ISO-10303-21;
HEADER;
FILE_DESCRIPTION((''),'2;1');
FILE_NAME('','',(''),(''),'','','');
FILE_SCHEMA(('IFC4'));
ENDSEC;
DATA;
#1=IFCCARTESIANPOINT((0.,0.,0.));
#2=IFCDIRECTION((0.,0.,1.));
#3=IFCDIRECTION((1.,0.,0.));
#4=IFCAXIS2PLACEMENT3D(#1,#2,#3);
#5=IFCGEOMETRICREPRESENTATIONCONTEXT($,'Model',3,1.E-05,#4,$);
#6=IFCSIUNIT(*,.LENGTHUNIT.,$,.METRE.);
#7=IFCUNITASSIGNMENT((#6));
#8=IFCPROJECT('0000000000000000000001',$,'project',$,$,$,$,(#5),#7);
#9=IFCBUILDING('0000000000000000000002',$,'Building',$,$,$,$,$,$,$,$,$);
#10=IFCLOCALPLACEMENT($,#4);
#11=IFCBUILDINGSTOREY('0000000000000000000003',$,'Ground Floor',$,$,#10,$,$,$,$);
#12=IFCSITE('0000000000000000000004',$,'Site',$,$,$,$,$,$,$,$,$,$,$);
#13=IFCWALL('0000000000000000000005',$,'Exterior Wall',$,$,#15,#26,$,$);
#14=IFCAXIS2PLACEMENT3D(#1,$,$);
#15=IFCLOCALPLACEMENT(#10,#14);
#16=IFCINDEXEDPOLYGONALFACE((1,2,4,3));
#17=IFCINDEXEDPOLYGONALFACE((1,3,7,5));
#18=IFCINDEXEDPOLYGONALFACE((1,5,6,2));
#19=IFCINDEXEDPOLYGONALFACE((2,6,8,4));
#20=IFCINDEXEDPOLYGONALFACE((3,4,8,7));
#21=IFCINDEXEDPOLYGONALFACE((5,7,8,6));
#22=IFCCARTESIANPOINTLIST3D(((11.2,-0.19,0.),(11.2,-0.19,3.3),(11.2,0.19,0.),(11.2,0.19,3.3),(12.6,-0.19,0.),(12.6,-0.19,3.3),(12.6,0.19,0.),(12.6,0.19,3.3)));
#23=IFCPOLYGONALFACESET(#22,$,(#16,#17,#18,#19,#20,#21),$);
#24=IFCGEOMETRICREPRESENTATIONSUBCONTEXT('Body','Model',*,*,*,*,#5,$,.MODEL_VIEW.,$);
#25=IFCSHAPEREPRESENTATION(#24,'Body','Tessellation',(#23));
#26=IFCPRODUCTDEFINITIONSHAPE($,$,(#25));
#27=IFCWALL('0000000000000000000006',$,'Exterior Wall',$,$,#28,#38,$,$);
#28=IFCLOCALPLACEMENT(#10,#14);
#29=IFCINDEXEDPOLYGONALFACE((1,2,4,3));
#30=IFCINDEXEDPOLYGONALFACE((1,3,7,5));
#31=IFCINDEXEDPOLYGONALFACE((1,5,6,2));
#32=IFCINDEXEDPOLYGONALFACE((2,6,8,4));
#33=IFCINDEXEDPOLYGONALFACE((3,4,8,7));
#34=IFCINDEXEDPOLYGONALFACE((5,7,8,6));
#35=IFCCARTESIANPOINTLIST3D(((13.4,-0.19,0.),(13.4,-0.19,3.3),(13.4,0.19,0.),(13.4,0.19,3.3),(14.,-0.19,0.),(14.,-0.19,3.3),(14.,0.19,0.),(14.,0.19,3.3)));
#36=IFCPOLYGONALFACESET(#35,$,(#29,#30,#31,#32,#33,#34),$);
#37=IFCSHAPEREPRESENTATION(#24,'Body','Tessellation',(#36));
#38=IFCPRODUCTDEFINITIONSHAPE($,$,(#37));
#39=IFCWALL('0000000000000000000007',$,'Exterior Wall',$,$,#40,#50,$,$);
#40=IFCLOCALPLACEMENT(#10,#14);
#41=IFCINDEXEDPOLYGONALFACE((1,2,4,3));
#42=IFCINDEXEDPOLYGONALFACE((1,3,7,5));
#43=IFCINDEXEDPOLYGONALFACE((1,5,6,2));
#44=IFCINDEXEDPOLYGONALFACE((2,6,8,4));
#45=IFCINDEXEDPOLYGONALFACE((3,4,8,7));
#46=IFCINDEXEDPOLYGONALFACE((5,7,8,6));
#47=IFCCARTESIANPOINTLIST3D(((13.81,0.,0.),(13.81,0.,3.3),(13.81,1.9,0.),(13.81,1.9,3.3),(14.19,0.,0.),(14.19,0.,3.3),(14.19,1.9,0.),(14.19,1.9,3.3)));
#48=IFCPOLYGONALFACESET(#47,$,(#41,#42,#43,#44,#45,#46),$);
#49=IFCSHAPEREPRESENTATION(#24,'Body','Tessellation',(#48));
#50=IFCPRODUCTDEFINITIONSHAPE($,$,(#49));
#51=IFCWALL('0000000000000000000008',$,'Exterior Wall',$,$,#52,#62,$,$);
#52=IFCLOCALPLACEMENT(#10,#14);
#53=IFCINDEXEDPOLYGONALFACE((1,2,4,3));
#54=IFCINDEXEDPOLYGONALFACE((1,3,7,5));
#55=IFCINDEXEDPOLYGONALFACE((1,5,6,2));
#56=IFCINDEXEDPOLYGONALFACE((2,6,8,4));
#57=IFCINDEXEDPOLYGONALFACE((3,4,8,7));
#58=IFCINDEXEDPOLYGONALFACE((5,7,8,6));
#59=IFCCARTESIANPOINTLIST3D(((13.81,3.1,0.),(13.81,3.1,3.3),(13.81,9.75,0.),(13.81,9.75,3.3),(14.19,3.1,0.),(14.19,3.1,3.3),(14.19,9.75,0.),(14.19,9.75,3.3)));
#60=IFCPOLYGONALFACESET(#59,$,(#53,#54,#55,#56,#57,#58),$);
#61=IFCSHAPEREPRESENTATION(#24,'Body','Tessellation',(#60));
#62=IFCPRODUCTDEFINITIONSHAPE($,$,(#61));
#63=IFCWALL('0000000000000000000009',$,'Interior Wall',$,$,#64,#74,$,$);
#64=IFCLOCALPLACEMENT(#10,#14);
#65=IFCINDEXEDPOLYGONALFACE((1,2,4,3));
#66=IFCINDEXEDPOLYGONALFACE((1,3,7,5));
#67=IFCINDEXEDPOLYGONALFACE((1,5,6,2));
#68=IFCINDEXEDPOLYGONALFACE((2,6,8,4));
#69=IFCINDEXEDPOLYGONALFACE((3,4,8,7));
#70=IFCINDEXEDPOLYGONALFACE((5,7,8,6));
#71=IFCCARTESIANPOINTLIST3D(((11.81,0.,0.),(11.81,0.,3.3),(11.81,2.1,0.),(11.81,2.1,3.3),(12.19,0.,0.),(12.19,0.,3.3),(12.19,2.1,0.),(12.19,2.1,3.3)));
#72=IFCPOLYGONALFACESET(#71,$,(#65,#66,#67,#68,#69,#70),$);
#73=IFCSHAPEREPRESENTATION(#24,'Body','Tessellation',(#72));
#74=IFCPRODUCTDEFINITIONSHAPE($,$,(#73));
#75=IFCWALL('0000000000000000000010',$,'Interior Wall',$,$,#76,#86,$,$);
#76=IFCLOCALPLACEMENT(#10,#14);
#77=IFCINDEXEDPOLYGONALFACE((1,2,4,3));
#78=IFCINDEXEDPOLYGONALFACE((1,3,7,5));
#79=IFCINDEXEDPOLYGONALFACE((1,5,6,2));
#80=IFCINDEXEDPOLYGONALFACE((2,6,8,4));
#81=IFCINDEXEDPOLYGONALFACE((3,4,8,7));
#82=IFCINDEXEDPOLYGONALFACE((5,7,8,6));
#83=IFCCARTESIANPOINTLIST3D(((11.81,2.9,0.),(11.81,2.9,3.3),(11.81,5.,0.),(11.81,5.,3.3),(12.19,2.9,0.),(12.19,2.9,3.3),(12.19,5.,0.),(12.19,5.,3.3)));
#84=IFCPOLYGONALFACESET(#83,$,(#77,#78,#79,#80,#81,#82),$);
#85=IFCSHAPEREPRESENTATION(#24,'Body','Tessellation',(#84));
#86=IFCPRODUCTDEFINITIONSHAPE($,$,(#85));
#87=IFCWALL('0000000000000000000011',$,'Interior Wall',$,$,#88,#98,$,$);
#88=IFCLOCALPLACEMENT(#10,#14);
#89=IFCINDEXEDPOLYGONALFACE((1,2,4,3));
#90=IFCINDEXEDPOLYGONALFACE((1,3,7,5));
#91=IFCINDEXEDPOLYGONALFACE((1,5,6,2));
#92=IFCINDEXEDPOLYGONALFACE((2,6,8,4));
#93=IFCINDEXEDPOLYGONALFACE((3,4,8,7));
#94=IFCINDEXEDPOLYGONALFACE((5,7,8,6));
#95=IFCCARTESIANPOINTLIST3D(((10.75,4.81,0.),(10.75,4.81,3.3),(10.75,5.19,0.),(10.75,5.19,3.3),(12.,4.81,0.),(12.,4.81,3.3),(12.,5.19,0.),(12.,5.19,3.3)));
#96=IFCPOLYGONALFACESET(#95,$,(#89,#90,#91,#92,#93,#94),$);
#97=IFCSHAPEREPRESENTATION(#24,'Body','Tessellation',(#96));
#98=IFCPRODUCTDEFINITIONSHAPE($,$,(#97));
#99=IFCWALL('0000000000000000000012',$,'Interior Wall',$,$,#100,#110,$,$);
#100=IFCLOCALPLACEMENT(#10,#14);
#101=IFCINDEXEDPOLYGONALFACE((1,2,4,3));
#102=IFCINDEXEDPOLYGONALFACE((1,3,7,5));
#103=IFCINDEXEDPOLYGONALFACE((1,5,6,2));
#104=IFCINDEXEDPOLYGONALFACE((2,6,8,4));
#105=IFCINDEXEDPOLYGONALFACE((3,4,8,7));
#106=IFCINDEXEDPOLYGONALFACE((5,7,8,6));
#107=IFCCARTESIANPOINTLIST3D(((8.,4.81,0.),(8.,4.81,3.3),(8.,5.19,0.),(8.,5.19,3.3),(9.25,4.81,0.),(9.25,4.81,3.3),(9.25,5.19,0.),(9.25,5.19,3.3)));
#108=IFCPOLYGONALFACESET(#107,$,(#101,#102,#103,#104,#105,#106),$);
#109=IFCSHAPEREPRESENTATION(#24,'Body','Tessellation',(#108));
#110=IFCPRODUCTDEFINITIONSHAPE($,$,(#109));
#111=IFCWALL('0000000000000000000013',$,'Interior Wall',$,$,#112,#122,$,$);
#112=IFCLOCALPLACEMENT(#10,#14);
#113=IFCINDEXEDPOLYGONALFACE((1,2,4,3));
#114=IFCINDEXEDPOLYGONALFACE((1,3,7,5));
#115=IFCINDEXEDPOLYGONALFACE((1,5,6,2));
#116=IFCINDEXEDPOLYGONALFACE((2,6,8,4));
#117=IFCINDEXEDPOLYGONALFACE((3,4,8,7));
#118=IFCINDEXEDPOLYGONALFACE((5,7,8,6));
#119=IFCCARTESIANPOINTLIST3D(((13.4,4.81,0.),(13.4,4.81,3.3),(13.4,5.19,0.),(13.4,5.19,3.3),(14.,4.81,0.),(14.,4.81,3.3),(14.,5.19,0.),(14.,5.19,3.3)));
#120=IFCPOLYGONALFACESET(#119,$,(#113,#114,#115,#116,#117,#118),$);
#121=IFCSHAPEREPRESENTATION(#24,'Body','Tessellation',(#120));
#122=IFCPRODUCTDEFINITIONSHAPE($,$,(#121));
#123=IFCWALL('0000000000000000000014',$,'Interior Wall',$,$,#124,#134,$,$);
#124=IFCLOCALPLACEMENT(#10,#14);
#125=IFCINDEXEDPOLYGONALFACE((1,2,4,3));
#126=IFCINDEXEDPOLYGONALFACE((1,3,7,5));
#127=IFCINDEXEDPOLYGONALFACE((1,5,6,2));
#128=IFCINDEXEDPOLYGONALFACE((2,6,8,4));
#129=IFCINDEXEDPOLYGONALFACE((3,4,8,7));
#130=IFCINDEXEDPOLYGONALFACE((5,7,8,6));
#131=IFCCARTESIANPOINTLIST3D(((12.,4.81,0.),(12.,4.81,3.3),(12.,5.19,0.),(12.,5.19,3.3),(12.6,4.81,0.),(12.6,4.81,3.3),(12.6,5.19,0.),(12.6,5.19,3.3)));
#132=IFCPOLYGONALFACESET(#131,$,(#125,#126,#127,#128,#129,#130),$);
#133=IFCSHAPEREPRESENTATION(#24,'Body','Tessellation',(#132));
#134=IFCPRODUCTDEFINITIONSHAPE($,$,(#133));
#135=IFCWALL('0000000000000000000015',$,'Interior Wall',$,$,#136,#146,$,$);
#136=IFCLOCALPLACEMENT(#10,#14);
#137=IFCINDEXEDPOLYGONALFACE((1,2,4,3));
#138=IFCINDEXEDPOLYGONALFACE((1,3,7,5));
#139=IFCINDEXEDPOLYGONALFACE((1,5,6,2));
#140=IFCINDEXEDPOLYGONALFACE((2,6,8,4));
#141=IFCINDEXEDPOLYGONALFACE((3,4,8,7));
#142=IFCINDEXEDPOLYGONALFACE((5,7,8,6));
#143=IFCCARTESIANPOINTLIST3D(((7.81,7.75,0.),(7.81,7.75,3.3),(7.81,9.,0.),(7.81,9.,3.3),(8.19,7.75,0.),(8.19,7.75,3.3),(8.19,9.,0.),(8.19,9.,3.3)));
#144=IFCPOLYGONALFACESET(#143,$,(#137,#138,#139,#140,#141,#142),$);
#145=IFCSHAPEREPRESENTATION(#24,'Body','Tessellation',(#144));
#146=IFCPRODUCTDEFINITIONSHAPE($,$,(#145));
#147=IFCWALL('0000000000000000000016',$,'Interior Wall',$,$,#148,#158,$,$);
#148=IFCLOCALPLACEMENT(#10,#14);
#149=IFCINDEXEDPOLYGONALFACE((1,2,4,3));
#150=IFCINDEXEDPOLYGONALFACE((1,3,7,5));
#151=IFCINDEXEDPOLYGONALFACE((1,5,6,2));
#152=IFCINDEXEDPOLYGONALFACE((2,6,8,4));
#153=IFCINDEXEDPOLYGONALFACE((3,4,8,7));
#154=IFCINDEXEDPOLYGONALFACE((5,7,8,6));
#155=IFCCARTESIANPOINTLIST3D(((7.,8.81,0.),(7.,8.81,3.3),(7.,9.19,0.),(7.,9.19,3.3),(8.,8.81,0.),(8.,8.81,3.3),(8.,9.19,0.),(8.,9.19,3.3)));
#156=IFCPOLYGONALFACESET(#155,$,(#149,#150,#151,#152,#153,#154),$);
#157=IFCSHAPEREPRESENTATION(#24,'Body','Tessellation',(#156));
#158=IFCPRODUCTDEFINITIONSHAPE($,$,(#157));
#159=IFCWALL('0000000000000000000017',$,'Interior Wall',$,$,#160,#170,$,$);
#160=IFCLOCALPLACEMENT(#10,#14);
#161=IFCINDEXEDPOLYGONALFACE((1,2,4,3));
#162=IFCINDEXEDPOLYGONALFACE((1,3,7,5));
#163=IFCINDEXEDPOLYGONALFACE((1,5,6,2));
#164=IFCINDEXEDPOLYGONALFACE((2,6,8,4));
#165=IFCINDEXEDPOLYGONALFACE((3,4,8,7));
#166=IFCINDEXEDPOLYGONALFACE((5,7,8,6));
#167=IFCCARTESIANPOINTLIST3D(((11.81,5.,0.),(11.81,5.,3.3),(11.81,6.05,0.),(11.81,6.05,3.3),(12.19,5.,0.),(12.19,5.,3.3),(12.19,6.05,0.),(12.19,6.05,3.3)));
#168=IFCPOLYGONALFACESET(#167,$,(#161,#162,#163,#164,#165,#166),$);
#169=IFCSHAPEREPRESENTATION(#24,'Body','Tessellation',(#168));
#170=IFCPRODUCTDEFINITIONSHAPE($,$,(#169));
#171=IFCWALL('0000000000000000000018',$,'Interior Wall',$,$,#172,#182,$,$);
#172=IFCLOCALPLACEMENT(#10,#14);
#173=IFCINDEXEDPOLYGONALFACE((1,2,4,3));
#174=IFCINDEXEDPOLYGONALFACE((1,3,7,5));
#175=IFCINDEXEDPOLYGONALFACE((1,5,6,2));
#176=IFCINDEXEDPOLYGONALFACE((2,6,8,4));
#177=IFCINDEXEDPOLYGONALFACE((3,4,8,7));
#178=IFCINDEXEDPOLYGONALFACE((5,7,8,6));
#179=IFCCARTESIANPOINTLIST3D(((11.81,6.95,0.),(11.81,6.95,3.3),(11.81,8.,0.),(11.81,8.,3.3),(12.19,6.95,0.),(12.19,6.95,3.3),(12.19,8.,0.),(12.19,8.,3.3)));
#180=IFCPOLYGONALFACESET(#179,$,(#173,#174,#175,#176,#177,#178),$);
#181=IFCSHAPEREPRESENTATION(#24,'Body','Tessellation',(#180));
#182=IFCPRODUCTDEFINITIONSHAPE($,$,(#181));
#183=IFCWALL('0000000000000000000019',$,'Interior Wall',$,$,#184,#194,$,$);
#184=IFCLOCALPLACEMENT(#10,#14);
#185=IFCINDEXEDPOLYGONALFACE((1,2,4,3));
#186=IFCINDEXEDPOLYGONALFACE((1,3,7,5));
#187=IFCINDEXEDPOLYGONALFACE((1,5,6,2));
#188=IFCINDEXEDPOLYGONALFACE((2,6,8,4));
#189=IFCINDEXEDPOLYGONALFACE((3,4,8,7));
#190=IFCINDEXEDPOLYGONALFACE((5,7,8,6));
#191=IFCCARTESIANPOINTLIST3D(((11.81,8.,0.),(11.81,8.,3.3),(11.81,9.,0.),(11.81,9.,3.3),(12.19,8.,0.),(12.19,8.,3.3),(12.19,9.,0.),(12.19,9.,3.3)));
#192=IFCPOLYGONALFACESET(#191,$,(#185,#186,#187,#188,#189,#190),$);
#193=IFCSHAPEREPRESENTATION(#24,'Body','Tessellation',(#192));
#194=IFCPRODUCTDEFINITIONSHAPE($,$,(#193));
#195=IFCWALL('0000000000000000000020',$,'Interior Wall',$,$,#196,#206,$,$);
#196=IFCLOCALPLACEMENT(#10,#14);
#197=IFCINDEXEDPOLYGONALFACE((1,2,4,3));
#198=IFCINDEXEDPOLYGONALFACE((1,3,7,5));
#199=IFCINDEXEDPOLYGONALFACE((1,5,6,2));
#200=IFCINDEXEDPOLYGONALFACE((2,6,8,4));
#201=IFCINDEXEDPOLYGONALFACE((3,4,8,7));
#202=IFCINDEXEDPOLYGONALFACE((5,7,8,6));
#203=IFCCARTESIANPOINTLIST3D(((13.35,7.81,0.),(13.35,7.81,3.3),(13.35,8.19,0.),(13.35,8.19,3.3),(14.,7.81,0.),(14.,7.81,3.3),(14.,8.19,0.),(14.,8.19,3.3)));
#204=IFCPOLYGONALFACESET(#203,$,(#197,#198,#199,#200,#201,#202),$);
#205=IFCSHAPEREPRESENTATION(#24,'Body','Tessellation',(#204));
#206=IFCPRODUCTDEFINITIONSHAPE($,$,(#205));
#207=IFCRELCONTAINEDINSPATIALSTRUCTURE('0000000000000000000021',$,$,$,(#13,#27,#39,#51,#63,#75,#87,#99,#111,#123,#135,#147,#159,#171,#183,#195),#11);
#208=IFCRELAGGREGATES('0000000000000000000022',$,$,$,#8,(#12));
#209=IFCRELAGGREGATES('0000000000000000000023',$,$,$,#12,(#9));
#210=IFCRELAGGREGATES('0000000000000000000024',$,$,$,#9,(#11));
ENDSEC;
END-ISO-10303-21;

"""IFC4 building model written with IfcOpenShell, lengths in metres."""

from ifc_helpers import new_model, si_unit, frame, origin_with_axes, place, context, subcontext, project, spatial, indexed_curve, outline, extrude, element, save


model = new_model("IFC4")

# Units and contexts
model_context = context("Model", 3, precision=1e-05, world=origin_with_axes())
body_context = subcontext(model_context, "Body", "Model", "MODEL_VIEW")
ifc_project = project(units=[si_unit("LENGTHUNIT", "METRE")], contexts=[model_context])

# Site, building, storey
site = spatial("IfcSite", under=ifc_project, Name="Site")
building = spatial("IfcBuilding", under=site, Name="Building")
storey_placement = place(None, origin_with_axes())
storey = spatial("IfcBuildingStorey", under=building, at=storey_placement, Name="Ground Floor")

# Walls
wall_1_placement = place(storey_placement, frame((11.2, 0.0, 0.0), z_axis=(0.0, 0.0, 1.0), x_axis=(1.0, 0.0, 0.0)))
element("IfcWall", 1, at=wall_1_placement, inside=storey, Name="Exterior Wall", context=body_context, shape_type="SweptSolid", body=[
    extrude(outline(indexed_curve([(0.0, 0.0), (0.0, 0.38), (1.4, 0.38), (1.4, 0.0), (0.0, 0.0)], self_intersect=False)), frame((0.0, -0.19, 0.0), z_axis=(0.0, 0.0, 1.0), x_axis=(1.0, 0.0, 0.0)), (0.0, 0.0, 1.0), 3.3),
])
wall_2_placement = place(storey_placement, frame((13.4, 0.0, 0.0), z_axis=(0.0, 0.0, 1.0), x_axis=(1.0, 0.0, 0.0)))
element("IfcWall", 2, at=wall_2_placement, inside=storey, Name="Exterior Wall", context=body_context, shape_type="SweptSolid", body=[
    extrude(outline(indexed_curve([(0.0, 0.0), (0.0, 0.38), (0.6, 0.38), (0.6, 0.0), (0.0, 0.0)], self_intersect=False)), frame((0.0, -0.19, 0.0), z_axis=(0.0, 0.0, 1.0), x_axis=(1.0, 0.0, 0.0)), (0.0, 0.0, 1.0), 3.3),
])
wall_3_placement = place(storey_placement, frame((14.0, 0.0, 0.0), z_axis=(0.0, 0.0, 1.0), x_axis=(0.0, 1.0, 0.0)))
element("IfcWall", 3, at=wall_3_placement, inside=storey, Name="Exterior Wall", context=body_context, shape_type="SweptSolid", body=[
    extrude(outline(indexed_curve([(0.0, 0.0), (0.0, 0.38), (1.9, 0.38), (1.9, 0.0), (0.0, 0.0)], self_intersect=False)), frame((0.0, -0.19, 0.0), z_axis=(0.0, 0.0, 1.0), x_axis=(1.0, 0.0, 0.0)), (0.0, 0.0, 1.0), 3.3),
])
wall_4_placement = place(storey_placement, frame((14.0, 3.1, 0.0), z_axis=(0.0, 0.0, 1.0), x_axis=(0.0, 1.0, 0.0)))
element("IfcWall", 4, at=wall_4_placement, inside=storey, Name="Exterior Wall", context=body_context, shape_type="SweptSolid", body=[
    extrude(outline(indexed_curve([(0.0, 0.0), (0.0, 0.38), (6.65, 0.38), (6.65, 0.0), (0.0, 0.0)], self_intersect=False)), frame((0.0, -0.19, 0.0), z_axis=(0.0, 0.0, 1.0), x_axis=(1.0, 0.0, 0.0)), (0.0, 0.0, 1.0), 3.3),
])
for number, where, z_axis, x_axis, name in (
    (5, (12.0, 0.0, 0.0), (0.0, 0.0, 1.0), (0.0, 1.0, 0.0), "Interior Wall"),
    (6, (12.0, 2.9, 0.0), (0.0, 0.0, 1.0), (0.0, 1.0, 0.0), "Interior Wall"),
):
    element("IfcWall", number, at=place(storey_placement, frame(where, z_axis=z_axis, x_axis=x_axis)), inside=storey, Name=name, context=body_context, shape_type="SweptSolid", body=[
        extrude(outline(indexed_curve([(0.0, 0.0), (0.0, 0.38), (2.1, 0.38), (2.1, 0.0), (0.0, 0.0)], self_intersect=False)), frame((0.0, -0.19, 0.0), z_axis=(0.0, 0.0, 1.0), x_axis=(1.0, 0.0, 0.0)), (0.0, 0.0, 1.0), 3.3),
    ])
for number, where, z_axis, x_axis, name in (
    (7, (12.0, 5.0, 0.0), (0.0, 0.0, 1.0), (-1.0, 0.0, 0.0), "Interior Wall"),
    (8, (9.25, 5.0, 0.0), (0.0, 0.0, 1.0), (-1.0, 0.0, 0.0), "Interior Wall"),
):
    element("IfcWall", number, at=place(storey_placement, frame(where, z_axis=z_axis, x_axis=x_axis)), inside=storey, Name=name, context=body_context, shape_type="SweptSolid", body=[
        extrude(outline(indexed_curve([(0.0, 0.0), (0.0, 0.38), (1.25, 0.38), (1.25, 0.0), (0.0, 0.0)], self_intersect=False)), frame((0.0, -0.19, 0.0), z_axis=(0.0, 0.0, 1.0), x_axis=(1.0, 0.0, 0.0)), (0.0, 0.0, 1.0), 3.3),
    ])
for number, where, z_axis, x_axis, name in (
    (9, (14.0, 5.0, 0.0), (0.0, 0.0, 1.0), (-1.0, 0.0, 0.0), "Interior Wall"),
    (10, (12.6, 5.0, 0.0), (0.0, 0.0, 1.0), (-1.0, 0.0, 0.0), "Interior Wall"),
):
    element("IfcWall", number, at=place(storey_placement, frame(where, z_axis=z_axis, x_axis=x_axis)), inside=storey, Name=name, context=body_context, shape_type="SweptSolid", body=[
        extrude(outline(indexed_curve([(0.0, 0.0), (0.0, 0.38), (0.6, 0.38), (0.6, 0.0), (0.0, 0.0)], self_intersect=False)), frame((0.0, -0.19, 0.0), z_axis=(0.0, 0.0, 1.0), x_axis=(1.0, 0.0, 0.0)), (0.0, 0.0, 1.0), 3.3),
    ])
wall_5_placement = place(storey_placement, frame((8.0, 7.75, 0.0), z_axis=(0.0, 0.0, 1.0), x_axis=(0.0, 1.0, 0.0)))
element("IfcWall", 11, at=wall_5_placement, inside=storey, Name="Interior Wall", context=body_context, shape_type="SweptSolid", body=[
    extrude(outline(indexed_curve([(0.0, 0.0), (0.0, 0.38), (1.25, 0.38), (1.25, 0.0), (0.0, 0.0)], self_intersect=False)), frame((0.0, -0.19, 0.0), z_axis=(0.0, 0.0, 1.0), x_axis=(1.0, 0.0, 0.0)), (0.0, 0.0, 1.0), 3.3),
])
wall_6_placement = place(storey_placement, frame((8.0, 9.0, 0.0), z_axis=(0.0, 0.0, 1.0), x_axis=(-1.0, 0.0, 0.0)))
element("IfcWall", 12, at=wall_6_placement, inside=storey, Name="Interior Wall", context=body_context, shape_type="SweptSolid", body=[
    extrude(outline(indexed_curve([(0.0, 0.0), (0.0, 0.38), (1.0, 0.38), (1.0, 0.0), (0.0, 0.0)], self_intersect=False)), frame((0.0, -0.19, 0.0), z_axis=(0.0, 0.0, 1.0), x_axis=(1.0, 0.0, 0.0)), (0.0, 0.0, 1.0), 3.3),
])
for number, where, z_axis, x_axis, name in (
    (13, (12.0, 5.0, 0.0), (0.0, 0.0, 1.0), (0.0, 1.0, 0.0), "Interior Wall"),
    (14, (12.0, 6.95, 0.0), (0.0, 0.0, 1.0), (0.0, 1.0, 0.0), "Interior Wall"),
):
    element("IfcWall", number, at=place(storey_placement, frame(where, z_axis=z_axis, x_axis=x_axis)), inside=storey, Name=name, context=body_context, shape_type="SweptSolid", body=[
        extrude(outline(indexed_curve([(0.0, 0.0), (0.0, 0.38), (1.05, 0.38), (1.05, 0.0), (0.0, 0.0)], self_intersect=False)), frame((0.0, -0.19, 0.0), z_axis=(0.0, 0.0, 1.0), x_axis=(1.0, 0.0, 0.0)), (0.0, 0.0, 1.0), 3.3),
    ])
wall_7_placement = place(storey_placement, frame((12.0, 8.0, 0.0), z_axis=(0.0, 0.0, 1.0), x_axis=(0.0, 1.0, 0.0)))
element("IfcWall", 15, at=wall_7_placement, inside=storey, Name="Interior Wall", context=body_context, shape_type="SweptSolid", body=[
    extrude(outline(indexed_curve([(0.0, 0.0), (0.0, 0.38), (1.0, 0.38), (1.0, 0.0), (0.0, 0.0)], self_intersect=False)), frame((0.0, -0.19, 0.0), z_axis=(0.0, 0.0, 1.0), x_axis=(1.0, 0.0, 0.0)), (0.0, 0.0, 1.0), 3.3),
])
for number, where, z_axis, x_axis, name in (
    (16, (14.0, 8.0, 0.0), (0.0, 0.0, 1.0), (-1.0, 0.0, 0.0), "Interior Wall"),
):
    element("IfcWall", number, at=place(storey_placement, frame(where, z_axis=z_axis, x_axis=x_axis)), inside=storey, Name=name, context=body_context, shape_type="SweptSolid", body=[
        extrude(outline(indexed_curve([(0.0, 0.0), (0.0, 0.38), (0.65, 0.38), (0.65, 0.0), (0.0, 0.0)], self_intersect=False)), frame((0.0, -0.19, 0.0), z_axis=(0.0, 0.0, 1.0), x_axis=(1.0, 0.0, 0.0)), (0.0, 0.0, 1.0), 3.3),
    ])

save(model, "model.ifc")
